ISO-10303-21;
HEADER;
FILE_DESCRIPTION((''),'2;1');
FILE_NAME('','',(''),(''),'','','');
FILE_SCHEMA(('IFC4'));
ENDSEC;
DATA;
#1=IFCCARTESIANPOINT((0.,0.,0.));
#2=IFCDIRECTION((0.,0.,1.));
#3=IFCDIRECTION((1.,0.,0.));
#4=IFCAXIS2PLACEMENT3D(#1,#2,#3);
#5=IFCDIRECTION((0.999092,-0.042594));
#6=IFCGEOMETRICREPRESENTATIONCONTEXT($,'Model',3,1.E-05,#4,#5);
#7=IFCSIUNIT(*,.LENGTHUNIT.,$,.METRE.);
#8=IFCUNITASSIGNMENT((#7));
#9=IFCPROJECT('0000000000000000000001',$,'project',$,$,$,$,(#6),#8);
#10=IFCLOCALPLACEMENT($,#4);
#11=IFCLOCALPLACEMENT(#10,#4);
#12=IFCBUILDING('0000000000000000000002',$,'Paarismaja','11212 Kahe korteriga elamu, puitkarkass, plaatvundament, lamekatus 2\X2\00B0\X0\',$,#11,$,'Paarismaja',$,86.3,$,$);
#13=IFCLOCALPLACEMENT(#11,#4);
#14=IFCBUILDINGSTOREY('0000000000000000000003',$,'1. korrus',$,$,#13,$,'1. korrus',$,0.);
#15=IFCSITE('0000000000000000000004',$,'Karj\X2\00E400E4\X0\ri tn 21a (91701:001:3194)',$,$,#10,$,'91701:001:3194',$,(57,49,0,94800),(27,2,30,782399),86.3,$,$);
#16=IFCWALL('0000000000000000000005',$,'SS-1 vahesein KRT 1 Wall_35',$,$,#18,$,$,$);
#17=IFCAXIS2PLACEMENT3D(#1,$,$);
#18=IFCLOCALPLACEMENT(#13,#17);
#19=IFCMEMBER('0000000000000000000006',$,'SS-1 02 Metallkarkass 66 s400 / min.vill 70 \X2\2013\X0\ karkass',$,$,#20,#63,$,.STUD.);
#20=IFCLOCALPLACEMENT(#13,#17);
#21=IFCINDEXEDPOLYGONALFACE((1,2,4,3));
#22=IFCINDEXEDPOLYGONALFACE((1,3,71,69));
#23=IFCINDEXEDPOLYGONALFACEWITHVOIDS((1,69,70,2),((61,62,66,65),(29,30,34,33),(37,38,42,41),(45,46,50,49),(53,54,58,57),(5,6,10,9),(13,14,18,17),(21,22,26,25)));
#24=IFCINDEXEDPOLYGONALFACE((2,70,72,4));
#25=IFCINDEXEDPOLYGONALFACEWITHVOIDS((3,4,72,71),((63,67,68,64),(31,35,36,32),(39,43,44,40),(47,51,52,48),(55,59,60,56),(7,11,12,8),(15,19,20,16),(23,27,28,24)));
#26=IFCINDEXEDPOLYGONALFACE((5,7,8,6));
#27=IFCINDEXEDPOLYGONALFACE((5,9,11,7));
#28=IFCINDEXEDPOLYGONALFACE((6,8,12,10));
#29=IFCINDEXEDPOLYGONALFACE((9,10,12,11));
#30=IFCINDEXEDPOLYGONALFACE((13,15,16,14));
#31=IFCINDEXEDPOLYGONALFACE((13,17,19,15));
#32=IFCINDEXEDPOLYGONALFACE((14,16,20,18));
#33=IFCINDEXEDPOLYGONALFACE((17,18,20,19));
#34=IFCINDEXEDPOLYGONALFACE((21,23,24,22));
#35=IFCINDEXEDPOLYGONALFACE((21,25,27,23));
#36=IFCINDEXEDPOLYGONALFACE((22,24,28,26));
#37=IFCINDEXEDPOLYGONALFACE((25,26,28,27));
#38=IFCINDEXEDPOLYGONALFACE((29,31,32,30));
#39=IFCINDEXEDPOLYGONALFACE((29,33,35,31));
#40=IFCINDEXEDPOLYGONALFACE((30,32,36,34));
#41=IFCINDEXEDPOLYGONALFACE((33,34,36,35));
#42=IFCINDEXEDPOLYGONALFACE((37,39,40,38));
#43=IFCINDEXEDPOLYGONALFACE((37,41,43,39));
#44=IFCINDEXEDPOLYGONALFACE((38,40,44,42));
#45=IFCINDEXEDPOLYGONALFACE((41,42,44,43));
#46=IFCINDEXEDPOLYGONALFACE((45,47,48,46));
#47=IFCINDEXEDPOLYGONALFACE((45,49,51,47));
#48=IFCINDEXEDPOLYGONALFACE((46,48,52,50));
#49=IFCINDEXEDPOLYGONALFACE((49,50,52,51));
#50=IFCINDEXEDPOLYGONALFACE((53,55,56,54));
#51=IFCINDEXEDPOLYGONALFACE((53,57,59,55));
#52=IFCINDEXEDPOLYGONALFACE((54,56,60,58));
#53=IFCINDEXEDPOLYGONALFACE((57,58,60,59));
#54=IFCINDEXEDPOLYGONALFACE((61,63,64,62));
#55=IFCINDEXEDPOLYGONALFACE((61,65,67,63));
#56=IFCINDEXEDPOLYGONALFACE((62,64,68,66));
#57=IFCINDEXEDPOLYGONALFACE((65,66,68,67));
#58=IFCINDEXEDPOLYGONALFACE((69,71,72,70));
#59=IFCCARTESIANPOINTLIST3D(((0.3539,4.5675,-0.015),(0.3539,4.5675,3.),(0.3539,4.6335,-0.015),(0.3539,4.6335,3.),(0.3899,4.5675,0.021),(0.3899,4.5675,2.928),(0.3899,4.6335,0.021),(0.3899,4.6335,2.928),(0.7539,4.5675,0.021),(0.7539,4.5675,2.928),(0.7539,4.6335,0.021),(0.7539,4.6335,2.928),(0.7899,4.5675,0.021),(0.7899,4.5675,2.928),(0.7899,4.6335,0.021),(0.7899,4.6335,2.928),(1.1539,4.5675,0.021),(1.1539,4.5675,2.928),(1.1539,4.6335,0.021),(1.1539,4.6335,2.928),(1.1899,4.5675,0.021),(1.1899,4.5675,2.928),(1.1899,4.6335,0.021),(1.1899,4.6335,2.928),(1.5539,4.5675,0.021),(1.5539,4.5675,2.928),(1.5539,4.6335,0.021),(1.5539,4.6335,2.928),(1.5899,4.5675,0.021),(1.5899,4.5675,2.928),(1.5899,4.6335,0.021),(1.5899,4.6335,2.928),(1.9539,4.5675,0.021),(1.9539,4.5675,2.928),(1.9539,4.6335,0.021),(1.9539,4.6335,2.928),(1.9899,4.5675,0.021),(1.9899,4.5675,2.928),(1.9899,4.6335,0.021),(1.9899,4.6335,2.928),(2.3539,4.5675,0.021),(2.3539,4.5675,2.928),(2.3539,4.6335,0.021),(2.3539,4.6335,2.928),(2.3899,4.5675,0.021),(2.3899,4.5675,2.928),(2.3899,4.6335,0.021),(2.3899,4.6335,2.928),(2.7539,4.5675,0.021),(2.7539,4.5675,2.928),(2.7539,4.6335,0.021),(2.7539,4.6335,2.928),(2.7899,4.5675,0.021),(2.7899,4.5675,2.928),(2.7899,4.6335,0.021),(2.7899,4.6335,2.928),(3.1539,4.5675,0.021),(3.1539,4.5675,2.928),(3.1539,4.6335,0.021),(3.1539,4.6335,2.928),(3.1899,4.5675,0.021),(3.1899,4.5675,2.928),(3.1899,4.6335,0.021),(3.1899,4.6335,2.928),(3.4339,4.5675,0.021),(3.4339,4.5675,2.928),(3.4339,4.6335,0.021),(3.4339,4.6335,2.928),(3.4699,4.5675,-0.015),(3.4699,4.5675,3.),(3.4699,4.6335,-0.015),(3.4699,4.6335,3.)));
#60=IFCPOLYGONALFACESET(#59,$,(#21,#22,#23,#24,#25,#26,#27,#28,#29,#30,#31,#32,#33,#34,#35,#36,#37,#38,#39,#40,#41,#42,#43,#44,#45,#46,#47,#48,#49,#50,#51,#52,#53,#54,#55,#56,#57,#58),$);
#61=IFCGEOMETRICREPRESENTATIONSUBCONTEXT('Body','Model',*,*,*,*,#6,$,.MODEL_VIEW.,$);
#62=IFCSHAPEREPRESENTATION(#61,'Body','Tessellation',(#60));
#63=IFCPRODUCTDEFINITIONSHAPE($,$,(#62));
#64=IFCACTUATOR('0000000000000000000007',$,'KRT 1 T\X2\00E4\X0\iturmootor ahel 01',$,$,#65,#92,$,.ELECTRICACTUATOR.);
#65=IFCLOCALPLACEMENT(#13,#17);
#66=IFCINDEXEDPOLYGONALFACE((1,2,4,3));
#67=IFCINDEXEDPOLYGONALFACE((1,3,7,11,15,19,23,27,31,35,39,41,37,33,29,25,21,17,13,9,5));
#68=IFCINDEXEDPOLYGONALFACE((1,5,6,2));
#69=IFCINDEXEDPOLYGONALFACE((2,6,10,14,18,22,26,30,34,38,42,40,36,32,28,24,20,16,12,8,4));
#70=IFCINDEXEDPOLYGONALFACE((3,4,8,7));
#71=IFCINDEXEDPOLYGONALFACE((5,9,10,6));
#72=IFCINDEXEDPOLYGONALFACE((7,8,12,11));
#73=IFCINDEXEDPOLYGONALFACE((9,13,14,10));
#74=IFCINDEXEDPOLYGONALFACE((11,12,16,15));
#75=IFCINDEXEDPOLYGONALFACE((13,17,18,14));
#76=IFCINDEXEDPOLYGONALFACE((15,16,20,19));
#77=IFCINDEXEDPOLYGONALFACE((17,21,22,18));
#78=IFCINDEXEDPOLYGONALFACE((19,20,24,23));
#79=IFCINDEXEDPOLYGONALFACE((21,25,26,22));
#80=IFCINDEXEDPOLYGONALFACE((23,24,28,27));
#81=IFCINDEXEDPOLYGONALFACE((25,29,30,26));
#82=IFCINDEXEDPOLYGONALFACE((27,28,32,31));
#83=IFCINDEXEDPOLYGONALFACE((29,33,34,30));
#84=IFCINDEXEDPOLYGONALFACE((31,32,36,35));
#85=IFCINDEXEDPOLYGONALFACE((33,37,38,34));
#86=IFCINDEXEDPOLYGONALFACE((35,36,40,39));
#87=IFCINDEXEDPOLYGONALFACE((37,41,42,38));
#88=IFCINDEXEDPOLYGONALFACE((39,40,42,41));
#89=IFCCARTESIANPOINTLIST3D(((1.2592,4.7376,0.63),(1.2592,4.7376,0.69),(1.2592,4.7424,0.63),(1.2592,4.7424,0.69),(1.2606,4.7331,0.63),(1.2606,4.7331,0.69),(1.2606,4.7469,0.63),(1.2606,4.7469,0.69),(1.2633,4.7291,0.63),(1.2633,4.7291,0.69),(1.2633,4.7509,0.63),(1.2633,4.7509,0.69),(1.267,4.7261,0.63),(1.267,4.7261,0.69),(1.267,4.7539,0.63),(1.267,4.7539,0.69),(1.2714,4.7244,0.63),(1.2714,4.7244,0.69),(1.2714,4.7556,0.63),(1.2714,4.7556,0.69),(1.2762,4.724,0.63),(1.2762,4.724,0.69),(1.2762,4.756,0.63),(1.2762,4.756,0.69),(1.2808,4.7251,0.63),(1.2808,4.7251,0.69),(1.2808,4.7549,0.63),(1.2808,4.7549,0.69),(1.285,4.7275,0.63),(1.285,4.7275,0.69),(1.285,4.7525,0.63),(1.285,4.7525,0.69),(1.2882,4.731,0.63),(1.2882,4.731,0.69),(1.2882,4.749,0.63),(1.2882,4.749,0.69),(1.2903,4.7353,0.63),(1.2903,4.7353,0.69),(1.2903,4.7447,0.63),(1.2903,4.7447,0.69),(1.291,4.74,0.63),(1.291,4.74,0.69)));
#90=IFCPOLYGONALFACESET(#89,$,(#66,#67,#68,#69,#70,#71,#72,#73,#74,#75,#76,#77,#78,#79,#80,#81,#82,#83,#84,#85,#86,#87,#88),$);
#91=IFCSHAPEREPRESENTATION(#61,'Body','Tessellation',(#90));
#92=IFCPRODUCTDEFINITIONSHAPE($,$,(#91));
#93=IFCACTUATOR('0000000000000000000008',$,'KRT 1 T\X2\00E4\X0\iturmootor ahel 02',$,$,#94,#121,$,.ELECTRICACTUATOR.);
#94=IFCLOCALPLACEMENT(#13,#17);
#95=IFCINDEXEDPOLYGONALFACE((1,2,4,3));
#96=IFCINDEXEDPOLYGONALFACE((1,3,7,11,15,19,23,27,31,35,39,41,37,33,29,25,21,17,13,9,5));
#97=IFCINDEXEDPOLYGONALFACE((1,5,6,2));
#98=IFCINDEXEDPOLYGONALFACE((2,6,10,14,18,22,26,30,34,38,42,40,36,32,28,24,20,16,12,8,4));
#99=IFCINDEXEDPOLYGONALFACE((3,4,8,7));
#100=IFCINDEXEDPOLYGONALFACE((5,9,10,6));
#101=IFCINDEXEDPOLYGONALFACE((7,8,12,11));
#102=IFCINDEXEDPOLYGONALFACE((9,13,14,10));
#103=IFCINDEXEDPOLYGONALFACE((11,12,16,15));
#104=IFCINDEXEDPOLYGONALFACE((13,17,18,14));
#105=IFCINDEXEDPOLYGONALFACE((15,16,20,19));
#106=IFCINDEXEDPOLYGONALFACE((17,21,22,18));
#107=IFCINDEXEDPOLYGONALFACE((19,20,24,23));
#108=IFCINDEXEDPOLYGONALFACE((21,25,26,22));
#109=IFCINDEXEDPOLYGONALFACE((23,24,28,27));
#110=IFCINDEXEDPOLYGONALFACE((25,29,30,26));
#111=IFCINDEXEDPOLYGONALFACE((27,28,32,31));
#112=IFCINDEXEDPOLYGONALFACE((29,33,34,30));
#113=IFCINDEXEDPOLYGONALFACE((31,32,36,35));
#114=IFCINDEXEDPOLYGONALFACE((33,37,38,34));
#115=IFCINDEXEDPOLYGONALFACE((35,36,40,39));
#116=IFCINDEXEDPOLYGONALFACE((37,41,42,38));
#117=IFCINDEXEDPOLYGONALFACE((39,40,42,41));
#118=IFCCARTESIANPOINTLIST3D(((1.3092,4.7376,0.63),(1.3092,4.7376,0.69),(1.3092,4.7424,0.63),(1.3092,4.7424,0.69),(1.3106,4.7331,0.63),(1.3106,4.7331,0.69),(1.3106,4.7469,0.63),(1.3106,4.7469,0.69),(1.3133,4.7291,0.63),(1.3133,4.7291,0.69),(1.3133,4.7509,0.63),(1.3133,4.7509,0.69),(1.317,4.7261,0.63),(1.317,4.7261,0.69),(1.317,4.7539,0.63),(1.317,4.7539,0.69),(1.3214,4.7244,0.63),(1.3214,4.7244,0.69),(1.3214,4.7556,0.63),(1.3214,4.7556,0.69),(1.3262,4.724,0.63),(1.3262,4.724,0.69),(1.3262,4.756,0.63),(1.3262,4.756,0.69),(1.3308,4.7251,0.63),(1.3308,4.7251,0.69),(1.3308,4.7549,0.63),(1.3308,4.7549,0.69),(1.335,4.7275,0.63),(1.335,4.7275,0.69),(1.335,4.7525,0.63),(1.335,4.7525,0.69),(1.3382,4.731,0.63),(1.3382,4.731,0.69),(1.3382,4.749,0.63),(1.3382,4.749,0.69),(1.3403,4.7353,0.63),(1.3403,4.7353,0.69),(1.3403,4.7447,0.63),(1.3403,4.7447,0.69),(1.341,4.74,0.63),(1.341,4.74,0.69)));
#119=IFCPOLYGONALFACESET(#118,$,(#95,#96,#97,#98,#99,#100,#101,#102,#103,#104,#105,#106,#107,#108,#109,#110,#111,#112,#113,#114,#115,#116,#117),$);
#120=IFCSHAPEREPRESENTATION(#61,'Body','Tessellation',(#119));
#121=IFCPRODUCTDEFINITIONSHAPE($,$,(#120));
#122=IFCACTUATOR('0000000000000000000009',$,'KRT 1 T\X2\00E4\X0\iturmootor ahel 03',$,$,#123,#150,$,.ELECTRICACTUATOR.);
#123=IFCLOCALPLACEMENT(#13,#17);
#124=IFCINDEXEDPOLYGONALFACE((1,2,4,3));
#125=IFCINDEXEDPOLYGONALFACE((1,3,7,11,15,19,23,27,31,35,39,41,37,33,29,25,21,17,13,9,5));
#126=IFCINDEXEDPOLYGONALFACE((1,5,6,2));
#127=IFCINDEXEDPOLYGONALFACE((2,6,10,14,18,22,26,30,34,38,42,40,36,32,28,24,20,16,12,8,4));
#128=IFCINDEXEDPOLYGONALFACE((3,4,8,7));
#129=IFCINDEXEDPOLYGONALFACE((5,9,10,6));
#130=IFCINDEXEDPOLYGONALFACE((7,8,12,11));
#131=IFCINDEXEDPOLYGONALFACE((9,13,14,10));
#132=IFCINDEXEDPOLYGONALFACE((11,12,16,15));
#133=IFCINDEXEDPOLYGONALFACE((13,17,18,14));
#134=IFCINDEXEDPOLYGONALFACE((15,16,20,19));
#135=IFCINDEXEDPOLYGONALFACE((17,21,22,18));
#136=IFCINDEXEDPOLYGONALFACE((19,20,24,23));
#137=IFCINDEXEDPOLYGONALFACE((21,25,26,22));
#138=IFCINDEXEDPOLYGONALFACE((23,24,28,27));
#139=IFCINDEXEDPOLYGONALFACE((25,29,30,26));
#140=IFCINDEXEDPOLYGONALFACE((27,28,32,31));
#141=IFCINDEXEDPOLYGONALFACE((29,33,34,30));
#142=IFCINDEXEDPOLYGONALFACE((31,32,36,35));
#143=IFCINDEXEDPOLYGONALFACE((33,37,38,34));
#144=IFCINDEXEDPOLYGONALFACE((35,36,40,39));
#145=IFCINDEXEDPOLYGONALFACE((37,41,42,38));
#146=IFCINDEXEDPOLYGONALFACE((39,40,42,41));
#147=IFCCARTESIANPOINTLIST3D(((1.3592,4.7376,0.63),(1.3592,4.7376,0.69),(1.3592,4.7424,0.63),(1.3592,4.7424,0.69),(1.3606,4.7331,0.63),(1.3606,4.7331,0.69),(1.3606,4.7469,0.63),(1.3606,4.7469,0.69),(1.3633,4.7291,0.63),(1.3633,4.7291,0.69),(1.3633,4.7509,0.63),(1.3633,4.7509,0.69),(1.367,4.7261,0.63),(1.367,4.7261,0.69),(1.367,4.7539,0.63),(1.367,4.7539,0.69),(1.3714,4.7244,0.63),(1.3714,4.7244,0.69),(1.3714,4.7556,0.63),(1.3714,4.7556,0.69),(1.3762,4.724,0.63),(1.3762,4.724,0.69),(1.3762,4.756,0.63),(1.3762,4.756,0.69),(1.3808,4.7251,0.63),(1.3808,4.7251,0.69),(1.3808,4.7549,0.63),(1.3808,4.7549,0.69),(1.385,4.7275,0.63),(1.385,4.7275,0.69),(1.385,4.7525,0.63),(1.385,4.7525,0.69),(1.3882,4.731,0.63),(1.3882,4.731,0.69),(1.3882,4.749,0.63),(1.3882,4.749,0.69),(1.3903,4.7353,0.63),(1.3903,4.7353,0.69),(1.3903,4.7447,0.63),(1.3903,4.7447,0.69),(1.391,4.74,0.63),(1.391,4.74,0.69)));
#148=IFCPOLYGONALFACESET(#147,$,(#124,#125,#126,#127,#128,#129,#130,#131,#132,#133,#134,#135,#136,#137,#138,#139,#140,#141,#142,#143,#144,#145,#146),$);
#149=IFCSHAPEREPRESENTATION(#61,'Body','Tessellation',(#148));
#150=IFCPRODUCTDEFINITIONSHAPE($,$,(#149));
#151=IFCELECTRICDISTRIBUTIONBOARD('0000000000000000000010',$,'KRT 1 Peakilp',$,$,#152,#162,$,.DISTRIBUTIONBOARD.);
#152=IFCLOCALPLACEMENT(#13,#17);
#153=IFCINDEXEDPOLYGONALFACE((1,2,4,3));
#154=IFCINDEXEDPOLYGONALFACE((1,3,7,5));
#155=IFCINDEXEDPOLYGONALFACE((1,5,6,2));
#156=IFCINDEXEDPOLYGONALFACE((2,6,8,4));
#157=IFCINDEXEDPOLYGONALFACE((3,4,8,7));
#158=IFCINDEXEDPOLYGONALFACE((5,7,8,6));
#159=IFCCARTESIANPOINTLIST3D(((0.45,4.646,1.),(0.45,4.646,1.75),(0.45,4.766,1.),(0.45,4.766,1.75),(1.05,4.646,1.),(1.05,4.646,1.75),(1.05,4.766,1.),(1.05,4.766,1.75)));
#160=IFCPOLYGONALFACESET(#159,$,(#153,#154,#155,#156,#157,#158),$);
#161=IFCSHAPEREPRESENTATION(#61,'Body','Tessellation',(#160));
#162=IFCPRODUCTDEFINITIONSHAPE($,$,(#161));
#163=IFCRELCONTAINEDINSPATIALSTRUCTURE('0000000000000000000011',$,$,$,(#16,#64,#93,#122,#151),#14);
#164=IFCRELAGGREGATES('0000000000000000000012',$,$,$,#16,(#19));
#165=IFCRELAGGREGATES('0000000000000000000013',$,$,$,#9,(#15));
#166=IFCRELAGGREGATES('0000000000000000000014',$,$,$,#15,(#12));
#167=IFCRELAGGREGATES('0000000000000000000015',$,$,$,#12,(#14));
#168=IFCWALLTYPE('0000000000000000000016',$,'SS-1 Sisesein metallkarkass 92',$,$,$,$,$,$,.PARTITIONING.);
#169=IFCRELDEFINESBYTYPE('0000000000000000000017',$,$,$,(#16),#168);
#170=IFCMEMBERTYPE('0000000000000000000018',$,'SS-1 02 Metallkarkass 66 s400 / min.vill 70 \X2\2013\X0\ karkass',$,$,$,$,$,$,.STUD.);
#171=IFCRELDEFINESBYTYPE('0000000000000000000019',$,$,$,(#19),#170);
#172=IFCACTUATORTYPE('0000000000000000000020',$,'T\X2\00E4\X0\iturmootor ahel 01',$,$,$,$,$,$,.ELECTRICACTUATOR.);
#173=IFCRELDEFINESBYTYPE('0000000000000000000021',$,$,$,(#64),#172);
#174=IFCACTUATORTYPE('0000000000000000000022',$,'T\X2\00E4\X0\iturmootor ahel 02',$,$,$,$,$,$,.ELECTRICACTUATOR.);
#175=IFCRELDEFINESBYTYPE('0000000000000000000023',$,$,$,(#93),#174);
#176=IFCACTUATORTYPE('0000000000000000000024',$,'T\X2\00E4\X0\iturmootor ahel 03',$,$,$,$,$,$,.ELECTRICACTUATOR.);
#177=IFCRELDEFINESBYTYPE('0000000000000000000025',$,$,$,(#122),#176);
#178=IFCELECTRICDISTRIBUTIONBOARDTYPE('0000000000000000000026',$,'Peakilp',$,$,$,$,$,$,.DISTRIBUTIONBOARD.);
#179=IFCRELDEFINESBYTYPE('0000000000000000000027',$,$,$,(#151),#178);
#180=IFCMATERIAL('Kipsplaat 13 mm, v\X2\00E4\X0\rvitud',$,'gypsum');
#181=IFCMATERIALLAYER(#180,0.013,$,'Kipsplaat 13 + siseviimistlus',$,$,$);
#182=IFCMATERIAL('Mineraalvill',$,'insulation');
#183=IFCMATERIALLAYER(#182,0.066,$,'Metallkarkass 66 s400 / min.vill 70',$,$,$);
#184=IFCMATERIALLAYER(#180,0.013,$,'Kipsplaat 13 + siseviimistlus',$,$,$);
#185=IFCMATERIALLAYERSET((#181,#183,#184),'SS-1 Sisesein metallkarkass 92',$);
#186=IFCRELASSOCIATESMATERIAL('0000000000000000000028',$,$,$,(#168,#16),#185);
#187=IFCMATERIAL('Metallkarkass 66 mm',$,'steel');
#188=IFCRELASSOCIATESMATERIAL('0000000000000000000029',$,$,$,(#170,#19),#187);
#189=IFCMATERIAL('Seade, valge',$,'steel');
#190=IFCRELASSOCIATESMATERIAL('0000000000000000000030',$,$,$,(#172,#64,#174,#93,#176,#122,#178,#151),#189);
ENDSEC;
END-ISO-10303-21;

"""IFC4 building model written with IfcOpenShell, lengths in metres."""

from ifc_helpers import new_model, si_unit, direction, frame, origin_with_axes, place, context, subcontext, project, spatial, indexed_curve, circle, outline, extrude, material, layer, layer_set, layer_usage, type_object, element, aggregate, save


model = new_model("IFC4")

# Units and contexts
model_context = context("Model", 3, precision=1e-05, world=origin_with_axes(), true_north=direction((0.999092, -0.042594)))
body_context = subcontext(model_context, "Body", "Model", "MODEL_VIEW")
ifc_project = project(units=[si_unit("LENGTHUNIT", "METRE")], contexts=[model_context])

# Site, building, storey
site_placement = place(None, origin_with_axes())
site = spatial("IfcSite", under=ifc_project, at=site_placement, Name="Karjääri tn 21a (91701:001:3194)", LongName="91701:001:3194", RefLatitude=(57, 49, 0, 94800), RefLongitude=(27, 2, 30, 782399), RefElevation=86.3)
building_placement = place(site_placement, origin_with_axes())
building = spatial("IfcBuilding", under=site, at=building_placement, Name="Paarismaja", Description="11212 Kahe korteriga elamu, puitkarkass, plaatvundament, lamekatus 2°", LongName="Paarismaja", ElevationOfRefHeight=86.3)
storey_placement = place(building_placement, origin_with_axes())
storey = spatial("IfcBuildingStorey", under=building, at=storey_placement, Name="1. korrus", LongName="1. korrus", Elevation=0.0)

# Wall, member
ifc_material_1 = material(Name="Kipsplaat 13 mm, värvitud", Category="gypsum")
ifc_layer_1 = layer(ifc_material_1, 0.013, Name="Kipsplaat 13 + siseviimistlus")
ifc_material_2 = material(Name="Mineraalvill", Category="insulation")
ifc_layer_2 = layer(ifc_material_2, 0.066, Name="Metallkarkass 66 s400 / min.vill 70")
ifc_layer_3 = layer(ifc_material_1, 0.013, Name="Kipsplaat 13 + siseviimistlus")
ifc_layer_set = layer_set([ifc_layer_1, ifc_layer_2, ifc_layer_3], Name="SS-1 Sisesein metallkarkass 92")
ifc_layer_usage = layer_usage(ifc_layer_set, "AXIS2", "POSITIVE", 0.0)
wall_type = type_object("IfcWallType", Name="SS-1 Sisesein metallkarkass 92", PredefinedType="PARTITIONING", material=ifc_layer_set)
wall_placement = place(storey_placement, frame((0.3539, 4.5545, 0.0), z_axis=(0.0, 0.0, 1.0), x_axis=(1.0, 0.0, 0.0)))
wall = element("IfcWall", 1, at=wall_placement, inside=storey, type_object=wall_type, material=ifc_layer_usage, Name="SS-1 vahesein KRT 1 Wall_35")
ifc_material_3 = material(Name="Metallkarkass 66 mm", Category="steel")
member_type = type_object("IfcMemberType", Name="SS-1 02 Metallkarkass 66 s400 / min.vill 70 – karkass", PredefinedType="STUD", material=ifc_material_3)
member_placement = place(wall_placement, origin_with_axes())
member = element("IfcMember", 2, at=member_placement, type_object=member_type, material=ifc_material_3, Name="SS-1 02 Metallkarkass 66 s400 / min.vill 70 – karkass", PredefinedType="STUD", context=body_context, shape_type="SweptSolid", body=[
    extrude(outline(indexed_curve([(3.116, -0.015), (0.0, -0.015), (0.0, 3.0), (3.116, 3.0), (3.116, -0.015)], self_intersect=False), holes=[indexed_curve([(0.4, 0.021), (0.4, 2.928), (0.036, 2.928), (0.036, 0.021), (0.4, 0.021)], self_intersect=False), indexed_curve([(0.8, 0.021), (0.8, 2.928), (0.436, 2.928), (0.436, 0.021), (0.8, 0.021)], self_intersect=False), indexed_curve([(1.2, 0.021), (1.2, 2.928), (0.836, 2.928), (0.836, 0.021), (1.2, 0.021)], self_intersect=False), indexed_curve([(1.6, 0.021), (1.6, 2.928), (1.236, 2.928), (1.236, 0.021), (1.6, 0.021)], self_intersect=False), indexed_curve([(2.0, 2.928), (1.636, 2.928), (1.636, 0.021), (2.0, 0.021), (2.0, 2.928)], self_intersect=False), indexed_curve([(2.4, 2.928), (2.036, 2.928), (2.036, 0.021), (2.4, 0.021), (2.4, 2.928)], self_intersect=False), indexed_curve([(2.8, 2.928), (2.436, 2.928), (2.436, 0.021), (2.8, 0.021), (2.8, 2.928)], self_intersect=False), indexed_curve([(3.08, 2.928), (2.836, 2.928), (2.836, 0.021), (3.08, 0.021), (3.08, 2.928)], self_intersect=False)]), frame((0.0, 0.079, 0.0), z_axis=(0.0, -1.0, 0.0), x_axis=(1.0, 0.0, 0.0)), (0.0, 0.0, 1.0), 0.066),
])

# Actuators
ifc_material_4 = material(Name="Seade, valge", Category="steel")
actuator_type_1 = type_object("IfcActuatorType", Name="Täiturmootor ahel 01", PredefinedType="ELECTRICACTUATOR", material=ifc_material_4)
actuator_1_placement = place(storey_placement, frame((1.275, 4.74, 0.0), z_axis=(0.0, 0.0, 1.0), x_axis=(1.0, 0.0, 0.0)))
element("IfcActuator", 3, at=actuator_1_placement, inside=storey, type_object=actuator_type_1, material=ifc_material_4, Name="KRT 1 Täiturmootor ahel 01", PredefinedType="ELECTRICACTUATOR", context=body_context, shape_type="SweptSolid", body=[
    extrude(circle(Radius=0.016), frame((0.0, 0.0, 0.63), z_axis=(0.0, 0.0, 1.0), x_axis=(1.0, 0.0, 0.0)), (0.0, 0.0, 1.0), 0.06),
])
actuator_type_2 = type_object("IfcActuatorType", Name="Täiturmootor ahel 02", PredefinedType="ELECTRICACTUATOR", material=ifc_material_4)
actuator_2_placement = place(storey_placement, frame((1.325, 4.74, 0.0), z_axis=(0.0, 0.0, 1.0), x_axis=(1.0, 0.0, 0.0)))
element("IfcActuator", 4, at=actuator_2_placement, inside=storey, type_object=actuator_type_2, material=ifc_material_4, Name="KRT 1 Täiturmootor ahel 02", PredefinedType="ELECTRICACTUATOR", context=body_context, shape_type="SweptSolid", body=[
    extrude(circle(Radius=0.016), frame((0.0, 0.0, 0.63), z_axis=(0.0, 0.0, 1.0), x_axis=(1.0, 0.0, 0.0)), (0.0, 0.0, 1.0), 0.06),
])
actuator_type_3 = type_object("IfcActuatorType", Name="Täiturmootor ahel 03", PredefinedType="ELECTRICACTUATOR", material=ifc_material_4)
actuator_3_placement = place(storey_placement, frame((1.375, 4.74, 0.0), z_axis=(0.0, 0.0, 1.0), x_axis=(1.0, 0.0, 0.0)))
element("IfcActuator", 5, at=actuator_3_placement, inside=storey, type_object=actuator_type_3, material=ifc_material_4, Name="KRT 1 Täiturmootor ahel 03", PredefinedType="ELECTRICACTUATOR", context=body_context, shape_type="SweptSolid", body=[
    extrude(circle(Radius=0.016), frame((0.0, 0.0, 0.63), z_axis=(0.0, 0.0, 1.0), x_axis=(1.0, 0.0, 0.0)), (0.0, 0.0, 1.0), 0.06),
])

# Electric distribution board
electric_distribution_board_type = type_object("IfcElectricDistributionBoardType", Name="Peakilp", PredefinedType="DISTRIBUTIONBOARD", material=ifc_material_4)
electric_distribution_board_placement = place(storey_placement, frame((0.75, 4.706, 0.0), z_axis=(0.0, 0.0, 1.0), x_axis=(1.0, 0.0, 0.0)))
element("IfcElectricDistributionBoard", 6, at=electric_distribution_board_placement, inside=storey, type_object=electric_distribution_board_type, material=ifc_material_4, Name="KRT 1 Peakilp", PredefinedType="DISTRIBUTIONBOARD", context=body_context, shape_type="SweptSolid", body=[
    extrude(outline(indexed_curve([(-0.3, -0.06), (0.3, -0.06), (0.3, 0.06), (-0.3, 0.06), (-0.3, -0.06)], self_intersect=False)), frame((0.0, 0.0, 1.0), z_axis=(0.0, 0.0, 1.0), x_axis=(1.0, 0.0, 0.0)), (0.0, 0.0, 1.0), 0.75),
])

aggregate(wall, [member])

save(model, "model.ifc")
